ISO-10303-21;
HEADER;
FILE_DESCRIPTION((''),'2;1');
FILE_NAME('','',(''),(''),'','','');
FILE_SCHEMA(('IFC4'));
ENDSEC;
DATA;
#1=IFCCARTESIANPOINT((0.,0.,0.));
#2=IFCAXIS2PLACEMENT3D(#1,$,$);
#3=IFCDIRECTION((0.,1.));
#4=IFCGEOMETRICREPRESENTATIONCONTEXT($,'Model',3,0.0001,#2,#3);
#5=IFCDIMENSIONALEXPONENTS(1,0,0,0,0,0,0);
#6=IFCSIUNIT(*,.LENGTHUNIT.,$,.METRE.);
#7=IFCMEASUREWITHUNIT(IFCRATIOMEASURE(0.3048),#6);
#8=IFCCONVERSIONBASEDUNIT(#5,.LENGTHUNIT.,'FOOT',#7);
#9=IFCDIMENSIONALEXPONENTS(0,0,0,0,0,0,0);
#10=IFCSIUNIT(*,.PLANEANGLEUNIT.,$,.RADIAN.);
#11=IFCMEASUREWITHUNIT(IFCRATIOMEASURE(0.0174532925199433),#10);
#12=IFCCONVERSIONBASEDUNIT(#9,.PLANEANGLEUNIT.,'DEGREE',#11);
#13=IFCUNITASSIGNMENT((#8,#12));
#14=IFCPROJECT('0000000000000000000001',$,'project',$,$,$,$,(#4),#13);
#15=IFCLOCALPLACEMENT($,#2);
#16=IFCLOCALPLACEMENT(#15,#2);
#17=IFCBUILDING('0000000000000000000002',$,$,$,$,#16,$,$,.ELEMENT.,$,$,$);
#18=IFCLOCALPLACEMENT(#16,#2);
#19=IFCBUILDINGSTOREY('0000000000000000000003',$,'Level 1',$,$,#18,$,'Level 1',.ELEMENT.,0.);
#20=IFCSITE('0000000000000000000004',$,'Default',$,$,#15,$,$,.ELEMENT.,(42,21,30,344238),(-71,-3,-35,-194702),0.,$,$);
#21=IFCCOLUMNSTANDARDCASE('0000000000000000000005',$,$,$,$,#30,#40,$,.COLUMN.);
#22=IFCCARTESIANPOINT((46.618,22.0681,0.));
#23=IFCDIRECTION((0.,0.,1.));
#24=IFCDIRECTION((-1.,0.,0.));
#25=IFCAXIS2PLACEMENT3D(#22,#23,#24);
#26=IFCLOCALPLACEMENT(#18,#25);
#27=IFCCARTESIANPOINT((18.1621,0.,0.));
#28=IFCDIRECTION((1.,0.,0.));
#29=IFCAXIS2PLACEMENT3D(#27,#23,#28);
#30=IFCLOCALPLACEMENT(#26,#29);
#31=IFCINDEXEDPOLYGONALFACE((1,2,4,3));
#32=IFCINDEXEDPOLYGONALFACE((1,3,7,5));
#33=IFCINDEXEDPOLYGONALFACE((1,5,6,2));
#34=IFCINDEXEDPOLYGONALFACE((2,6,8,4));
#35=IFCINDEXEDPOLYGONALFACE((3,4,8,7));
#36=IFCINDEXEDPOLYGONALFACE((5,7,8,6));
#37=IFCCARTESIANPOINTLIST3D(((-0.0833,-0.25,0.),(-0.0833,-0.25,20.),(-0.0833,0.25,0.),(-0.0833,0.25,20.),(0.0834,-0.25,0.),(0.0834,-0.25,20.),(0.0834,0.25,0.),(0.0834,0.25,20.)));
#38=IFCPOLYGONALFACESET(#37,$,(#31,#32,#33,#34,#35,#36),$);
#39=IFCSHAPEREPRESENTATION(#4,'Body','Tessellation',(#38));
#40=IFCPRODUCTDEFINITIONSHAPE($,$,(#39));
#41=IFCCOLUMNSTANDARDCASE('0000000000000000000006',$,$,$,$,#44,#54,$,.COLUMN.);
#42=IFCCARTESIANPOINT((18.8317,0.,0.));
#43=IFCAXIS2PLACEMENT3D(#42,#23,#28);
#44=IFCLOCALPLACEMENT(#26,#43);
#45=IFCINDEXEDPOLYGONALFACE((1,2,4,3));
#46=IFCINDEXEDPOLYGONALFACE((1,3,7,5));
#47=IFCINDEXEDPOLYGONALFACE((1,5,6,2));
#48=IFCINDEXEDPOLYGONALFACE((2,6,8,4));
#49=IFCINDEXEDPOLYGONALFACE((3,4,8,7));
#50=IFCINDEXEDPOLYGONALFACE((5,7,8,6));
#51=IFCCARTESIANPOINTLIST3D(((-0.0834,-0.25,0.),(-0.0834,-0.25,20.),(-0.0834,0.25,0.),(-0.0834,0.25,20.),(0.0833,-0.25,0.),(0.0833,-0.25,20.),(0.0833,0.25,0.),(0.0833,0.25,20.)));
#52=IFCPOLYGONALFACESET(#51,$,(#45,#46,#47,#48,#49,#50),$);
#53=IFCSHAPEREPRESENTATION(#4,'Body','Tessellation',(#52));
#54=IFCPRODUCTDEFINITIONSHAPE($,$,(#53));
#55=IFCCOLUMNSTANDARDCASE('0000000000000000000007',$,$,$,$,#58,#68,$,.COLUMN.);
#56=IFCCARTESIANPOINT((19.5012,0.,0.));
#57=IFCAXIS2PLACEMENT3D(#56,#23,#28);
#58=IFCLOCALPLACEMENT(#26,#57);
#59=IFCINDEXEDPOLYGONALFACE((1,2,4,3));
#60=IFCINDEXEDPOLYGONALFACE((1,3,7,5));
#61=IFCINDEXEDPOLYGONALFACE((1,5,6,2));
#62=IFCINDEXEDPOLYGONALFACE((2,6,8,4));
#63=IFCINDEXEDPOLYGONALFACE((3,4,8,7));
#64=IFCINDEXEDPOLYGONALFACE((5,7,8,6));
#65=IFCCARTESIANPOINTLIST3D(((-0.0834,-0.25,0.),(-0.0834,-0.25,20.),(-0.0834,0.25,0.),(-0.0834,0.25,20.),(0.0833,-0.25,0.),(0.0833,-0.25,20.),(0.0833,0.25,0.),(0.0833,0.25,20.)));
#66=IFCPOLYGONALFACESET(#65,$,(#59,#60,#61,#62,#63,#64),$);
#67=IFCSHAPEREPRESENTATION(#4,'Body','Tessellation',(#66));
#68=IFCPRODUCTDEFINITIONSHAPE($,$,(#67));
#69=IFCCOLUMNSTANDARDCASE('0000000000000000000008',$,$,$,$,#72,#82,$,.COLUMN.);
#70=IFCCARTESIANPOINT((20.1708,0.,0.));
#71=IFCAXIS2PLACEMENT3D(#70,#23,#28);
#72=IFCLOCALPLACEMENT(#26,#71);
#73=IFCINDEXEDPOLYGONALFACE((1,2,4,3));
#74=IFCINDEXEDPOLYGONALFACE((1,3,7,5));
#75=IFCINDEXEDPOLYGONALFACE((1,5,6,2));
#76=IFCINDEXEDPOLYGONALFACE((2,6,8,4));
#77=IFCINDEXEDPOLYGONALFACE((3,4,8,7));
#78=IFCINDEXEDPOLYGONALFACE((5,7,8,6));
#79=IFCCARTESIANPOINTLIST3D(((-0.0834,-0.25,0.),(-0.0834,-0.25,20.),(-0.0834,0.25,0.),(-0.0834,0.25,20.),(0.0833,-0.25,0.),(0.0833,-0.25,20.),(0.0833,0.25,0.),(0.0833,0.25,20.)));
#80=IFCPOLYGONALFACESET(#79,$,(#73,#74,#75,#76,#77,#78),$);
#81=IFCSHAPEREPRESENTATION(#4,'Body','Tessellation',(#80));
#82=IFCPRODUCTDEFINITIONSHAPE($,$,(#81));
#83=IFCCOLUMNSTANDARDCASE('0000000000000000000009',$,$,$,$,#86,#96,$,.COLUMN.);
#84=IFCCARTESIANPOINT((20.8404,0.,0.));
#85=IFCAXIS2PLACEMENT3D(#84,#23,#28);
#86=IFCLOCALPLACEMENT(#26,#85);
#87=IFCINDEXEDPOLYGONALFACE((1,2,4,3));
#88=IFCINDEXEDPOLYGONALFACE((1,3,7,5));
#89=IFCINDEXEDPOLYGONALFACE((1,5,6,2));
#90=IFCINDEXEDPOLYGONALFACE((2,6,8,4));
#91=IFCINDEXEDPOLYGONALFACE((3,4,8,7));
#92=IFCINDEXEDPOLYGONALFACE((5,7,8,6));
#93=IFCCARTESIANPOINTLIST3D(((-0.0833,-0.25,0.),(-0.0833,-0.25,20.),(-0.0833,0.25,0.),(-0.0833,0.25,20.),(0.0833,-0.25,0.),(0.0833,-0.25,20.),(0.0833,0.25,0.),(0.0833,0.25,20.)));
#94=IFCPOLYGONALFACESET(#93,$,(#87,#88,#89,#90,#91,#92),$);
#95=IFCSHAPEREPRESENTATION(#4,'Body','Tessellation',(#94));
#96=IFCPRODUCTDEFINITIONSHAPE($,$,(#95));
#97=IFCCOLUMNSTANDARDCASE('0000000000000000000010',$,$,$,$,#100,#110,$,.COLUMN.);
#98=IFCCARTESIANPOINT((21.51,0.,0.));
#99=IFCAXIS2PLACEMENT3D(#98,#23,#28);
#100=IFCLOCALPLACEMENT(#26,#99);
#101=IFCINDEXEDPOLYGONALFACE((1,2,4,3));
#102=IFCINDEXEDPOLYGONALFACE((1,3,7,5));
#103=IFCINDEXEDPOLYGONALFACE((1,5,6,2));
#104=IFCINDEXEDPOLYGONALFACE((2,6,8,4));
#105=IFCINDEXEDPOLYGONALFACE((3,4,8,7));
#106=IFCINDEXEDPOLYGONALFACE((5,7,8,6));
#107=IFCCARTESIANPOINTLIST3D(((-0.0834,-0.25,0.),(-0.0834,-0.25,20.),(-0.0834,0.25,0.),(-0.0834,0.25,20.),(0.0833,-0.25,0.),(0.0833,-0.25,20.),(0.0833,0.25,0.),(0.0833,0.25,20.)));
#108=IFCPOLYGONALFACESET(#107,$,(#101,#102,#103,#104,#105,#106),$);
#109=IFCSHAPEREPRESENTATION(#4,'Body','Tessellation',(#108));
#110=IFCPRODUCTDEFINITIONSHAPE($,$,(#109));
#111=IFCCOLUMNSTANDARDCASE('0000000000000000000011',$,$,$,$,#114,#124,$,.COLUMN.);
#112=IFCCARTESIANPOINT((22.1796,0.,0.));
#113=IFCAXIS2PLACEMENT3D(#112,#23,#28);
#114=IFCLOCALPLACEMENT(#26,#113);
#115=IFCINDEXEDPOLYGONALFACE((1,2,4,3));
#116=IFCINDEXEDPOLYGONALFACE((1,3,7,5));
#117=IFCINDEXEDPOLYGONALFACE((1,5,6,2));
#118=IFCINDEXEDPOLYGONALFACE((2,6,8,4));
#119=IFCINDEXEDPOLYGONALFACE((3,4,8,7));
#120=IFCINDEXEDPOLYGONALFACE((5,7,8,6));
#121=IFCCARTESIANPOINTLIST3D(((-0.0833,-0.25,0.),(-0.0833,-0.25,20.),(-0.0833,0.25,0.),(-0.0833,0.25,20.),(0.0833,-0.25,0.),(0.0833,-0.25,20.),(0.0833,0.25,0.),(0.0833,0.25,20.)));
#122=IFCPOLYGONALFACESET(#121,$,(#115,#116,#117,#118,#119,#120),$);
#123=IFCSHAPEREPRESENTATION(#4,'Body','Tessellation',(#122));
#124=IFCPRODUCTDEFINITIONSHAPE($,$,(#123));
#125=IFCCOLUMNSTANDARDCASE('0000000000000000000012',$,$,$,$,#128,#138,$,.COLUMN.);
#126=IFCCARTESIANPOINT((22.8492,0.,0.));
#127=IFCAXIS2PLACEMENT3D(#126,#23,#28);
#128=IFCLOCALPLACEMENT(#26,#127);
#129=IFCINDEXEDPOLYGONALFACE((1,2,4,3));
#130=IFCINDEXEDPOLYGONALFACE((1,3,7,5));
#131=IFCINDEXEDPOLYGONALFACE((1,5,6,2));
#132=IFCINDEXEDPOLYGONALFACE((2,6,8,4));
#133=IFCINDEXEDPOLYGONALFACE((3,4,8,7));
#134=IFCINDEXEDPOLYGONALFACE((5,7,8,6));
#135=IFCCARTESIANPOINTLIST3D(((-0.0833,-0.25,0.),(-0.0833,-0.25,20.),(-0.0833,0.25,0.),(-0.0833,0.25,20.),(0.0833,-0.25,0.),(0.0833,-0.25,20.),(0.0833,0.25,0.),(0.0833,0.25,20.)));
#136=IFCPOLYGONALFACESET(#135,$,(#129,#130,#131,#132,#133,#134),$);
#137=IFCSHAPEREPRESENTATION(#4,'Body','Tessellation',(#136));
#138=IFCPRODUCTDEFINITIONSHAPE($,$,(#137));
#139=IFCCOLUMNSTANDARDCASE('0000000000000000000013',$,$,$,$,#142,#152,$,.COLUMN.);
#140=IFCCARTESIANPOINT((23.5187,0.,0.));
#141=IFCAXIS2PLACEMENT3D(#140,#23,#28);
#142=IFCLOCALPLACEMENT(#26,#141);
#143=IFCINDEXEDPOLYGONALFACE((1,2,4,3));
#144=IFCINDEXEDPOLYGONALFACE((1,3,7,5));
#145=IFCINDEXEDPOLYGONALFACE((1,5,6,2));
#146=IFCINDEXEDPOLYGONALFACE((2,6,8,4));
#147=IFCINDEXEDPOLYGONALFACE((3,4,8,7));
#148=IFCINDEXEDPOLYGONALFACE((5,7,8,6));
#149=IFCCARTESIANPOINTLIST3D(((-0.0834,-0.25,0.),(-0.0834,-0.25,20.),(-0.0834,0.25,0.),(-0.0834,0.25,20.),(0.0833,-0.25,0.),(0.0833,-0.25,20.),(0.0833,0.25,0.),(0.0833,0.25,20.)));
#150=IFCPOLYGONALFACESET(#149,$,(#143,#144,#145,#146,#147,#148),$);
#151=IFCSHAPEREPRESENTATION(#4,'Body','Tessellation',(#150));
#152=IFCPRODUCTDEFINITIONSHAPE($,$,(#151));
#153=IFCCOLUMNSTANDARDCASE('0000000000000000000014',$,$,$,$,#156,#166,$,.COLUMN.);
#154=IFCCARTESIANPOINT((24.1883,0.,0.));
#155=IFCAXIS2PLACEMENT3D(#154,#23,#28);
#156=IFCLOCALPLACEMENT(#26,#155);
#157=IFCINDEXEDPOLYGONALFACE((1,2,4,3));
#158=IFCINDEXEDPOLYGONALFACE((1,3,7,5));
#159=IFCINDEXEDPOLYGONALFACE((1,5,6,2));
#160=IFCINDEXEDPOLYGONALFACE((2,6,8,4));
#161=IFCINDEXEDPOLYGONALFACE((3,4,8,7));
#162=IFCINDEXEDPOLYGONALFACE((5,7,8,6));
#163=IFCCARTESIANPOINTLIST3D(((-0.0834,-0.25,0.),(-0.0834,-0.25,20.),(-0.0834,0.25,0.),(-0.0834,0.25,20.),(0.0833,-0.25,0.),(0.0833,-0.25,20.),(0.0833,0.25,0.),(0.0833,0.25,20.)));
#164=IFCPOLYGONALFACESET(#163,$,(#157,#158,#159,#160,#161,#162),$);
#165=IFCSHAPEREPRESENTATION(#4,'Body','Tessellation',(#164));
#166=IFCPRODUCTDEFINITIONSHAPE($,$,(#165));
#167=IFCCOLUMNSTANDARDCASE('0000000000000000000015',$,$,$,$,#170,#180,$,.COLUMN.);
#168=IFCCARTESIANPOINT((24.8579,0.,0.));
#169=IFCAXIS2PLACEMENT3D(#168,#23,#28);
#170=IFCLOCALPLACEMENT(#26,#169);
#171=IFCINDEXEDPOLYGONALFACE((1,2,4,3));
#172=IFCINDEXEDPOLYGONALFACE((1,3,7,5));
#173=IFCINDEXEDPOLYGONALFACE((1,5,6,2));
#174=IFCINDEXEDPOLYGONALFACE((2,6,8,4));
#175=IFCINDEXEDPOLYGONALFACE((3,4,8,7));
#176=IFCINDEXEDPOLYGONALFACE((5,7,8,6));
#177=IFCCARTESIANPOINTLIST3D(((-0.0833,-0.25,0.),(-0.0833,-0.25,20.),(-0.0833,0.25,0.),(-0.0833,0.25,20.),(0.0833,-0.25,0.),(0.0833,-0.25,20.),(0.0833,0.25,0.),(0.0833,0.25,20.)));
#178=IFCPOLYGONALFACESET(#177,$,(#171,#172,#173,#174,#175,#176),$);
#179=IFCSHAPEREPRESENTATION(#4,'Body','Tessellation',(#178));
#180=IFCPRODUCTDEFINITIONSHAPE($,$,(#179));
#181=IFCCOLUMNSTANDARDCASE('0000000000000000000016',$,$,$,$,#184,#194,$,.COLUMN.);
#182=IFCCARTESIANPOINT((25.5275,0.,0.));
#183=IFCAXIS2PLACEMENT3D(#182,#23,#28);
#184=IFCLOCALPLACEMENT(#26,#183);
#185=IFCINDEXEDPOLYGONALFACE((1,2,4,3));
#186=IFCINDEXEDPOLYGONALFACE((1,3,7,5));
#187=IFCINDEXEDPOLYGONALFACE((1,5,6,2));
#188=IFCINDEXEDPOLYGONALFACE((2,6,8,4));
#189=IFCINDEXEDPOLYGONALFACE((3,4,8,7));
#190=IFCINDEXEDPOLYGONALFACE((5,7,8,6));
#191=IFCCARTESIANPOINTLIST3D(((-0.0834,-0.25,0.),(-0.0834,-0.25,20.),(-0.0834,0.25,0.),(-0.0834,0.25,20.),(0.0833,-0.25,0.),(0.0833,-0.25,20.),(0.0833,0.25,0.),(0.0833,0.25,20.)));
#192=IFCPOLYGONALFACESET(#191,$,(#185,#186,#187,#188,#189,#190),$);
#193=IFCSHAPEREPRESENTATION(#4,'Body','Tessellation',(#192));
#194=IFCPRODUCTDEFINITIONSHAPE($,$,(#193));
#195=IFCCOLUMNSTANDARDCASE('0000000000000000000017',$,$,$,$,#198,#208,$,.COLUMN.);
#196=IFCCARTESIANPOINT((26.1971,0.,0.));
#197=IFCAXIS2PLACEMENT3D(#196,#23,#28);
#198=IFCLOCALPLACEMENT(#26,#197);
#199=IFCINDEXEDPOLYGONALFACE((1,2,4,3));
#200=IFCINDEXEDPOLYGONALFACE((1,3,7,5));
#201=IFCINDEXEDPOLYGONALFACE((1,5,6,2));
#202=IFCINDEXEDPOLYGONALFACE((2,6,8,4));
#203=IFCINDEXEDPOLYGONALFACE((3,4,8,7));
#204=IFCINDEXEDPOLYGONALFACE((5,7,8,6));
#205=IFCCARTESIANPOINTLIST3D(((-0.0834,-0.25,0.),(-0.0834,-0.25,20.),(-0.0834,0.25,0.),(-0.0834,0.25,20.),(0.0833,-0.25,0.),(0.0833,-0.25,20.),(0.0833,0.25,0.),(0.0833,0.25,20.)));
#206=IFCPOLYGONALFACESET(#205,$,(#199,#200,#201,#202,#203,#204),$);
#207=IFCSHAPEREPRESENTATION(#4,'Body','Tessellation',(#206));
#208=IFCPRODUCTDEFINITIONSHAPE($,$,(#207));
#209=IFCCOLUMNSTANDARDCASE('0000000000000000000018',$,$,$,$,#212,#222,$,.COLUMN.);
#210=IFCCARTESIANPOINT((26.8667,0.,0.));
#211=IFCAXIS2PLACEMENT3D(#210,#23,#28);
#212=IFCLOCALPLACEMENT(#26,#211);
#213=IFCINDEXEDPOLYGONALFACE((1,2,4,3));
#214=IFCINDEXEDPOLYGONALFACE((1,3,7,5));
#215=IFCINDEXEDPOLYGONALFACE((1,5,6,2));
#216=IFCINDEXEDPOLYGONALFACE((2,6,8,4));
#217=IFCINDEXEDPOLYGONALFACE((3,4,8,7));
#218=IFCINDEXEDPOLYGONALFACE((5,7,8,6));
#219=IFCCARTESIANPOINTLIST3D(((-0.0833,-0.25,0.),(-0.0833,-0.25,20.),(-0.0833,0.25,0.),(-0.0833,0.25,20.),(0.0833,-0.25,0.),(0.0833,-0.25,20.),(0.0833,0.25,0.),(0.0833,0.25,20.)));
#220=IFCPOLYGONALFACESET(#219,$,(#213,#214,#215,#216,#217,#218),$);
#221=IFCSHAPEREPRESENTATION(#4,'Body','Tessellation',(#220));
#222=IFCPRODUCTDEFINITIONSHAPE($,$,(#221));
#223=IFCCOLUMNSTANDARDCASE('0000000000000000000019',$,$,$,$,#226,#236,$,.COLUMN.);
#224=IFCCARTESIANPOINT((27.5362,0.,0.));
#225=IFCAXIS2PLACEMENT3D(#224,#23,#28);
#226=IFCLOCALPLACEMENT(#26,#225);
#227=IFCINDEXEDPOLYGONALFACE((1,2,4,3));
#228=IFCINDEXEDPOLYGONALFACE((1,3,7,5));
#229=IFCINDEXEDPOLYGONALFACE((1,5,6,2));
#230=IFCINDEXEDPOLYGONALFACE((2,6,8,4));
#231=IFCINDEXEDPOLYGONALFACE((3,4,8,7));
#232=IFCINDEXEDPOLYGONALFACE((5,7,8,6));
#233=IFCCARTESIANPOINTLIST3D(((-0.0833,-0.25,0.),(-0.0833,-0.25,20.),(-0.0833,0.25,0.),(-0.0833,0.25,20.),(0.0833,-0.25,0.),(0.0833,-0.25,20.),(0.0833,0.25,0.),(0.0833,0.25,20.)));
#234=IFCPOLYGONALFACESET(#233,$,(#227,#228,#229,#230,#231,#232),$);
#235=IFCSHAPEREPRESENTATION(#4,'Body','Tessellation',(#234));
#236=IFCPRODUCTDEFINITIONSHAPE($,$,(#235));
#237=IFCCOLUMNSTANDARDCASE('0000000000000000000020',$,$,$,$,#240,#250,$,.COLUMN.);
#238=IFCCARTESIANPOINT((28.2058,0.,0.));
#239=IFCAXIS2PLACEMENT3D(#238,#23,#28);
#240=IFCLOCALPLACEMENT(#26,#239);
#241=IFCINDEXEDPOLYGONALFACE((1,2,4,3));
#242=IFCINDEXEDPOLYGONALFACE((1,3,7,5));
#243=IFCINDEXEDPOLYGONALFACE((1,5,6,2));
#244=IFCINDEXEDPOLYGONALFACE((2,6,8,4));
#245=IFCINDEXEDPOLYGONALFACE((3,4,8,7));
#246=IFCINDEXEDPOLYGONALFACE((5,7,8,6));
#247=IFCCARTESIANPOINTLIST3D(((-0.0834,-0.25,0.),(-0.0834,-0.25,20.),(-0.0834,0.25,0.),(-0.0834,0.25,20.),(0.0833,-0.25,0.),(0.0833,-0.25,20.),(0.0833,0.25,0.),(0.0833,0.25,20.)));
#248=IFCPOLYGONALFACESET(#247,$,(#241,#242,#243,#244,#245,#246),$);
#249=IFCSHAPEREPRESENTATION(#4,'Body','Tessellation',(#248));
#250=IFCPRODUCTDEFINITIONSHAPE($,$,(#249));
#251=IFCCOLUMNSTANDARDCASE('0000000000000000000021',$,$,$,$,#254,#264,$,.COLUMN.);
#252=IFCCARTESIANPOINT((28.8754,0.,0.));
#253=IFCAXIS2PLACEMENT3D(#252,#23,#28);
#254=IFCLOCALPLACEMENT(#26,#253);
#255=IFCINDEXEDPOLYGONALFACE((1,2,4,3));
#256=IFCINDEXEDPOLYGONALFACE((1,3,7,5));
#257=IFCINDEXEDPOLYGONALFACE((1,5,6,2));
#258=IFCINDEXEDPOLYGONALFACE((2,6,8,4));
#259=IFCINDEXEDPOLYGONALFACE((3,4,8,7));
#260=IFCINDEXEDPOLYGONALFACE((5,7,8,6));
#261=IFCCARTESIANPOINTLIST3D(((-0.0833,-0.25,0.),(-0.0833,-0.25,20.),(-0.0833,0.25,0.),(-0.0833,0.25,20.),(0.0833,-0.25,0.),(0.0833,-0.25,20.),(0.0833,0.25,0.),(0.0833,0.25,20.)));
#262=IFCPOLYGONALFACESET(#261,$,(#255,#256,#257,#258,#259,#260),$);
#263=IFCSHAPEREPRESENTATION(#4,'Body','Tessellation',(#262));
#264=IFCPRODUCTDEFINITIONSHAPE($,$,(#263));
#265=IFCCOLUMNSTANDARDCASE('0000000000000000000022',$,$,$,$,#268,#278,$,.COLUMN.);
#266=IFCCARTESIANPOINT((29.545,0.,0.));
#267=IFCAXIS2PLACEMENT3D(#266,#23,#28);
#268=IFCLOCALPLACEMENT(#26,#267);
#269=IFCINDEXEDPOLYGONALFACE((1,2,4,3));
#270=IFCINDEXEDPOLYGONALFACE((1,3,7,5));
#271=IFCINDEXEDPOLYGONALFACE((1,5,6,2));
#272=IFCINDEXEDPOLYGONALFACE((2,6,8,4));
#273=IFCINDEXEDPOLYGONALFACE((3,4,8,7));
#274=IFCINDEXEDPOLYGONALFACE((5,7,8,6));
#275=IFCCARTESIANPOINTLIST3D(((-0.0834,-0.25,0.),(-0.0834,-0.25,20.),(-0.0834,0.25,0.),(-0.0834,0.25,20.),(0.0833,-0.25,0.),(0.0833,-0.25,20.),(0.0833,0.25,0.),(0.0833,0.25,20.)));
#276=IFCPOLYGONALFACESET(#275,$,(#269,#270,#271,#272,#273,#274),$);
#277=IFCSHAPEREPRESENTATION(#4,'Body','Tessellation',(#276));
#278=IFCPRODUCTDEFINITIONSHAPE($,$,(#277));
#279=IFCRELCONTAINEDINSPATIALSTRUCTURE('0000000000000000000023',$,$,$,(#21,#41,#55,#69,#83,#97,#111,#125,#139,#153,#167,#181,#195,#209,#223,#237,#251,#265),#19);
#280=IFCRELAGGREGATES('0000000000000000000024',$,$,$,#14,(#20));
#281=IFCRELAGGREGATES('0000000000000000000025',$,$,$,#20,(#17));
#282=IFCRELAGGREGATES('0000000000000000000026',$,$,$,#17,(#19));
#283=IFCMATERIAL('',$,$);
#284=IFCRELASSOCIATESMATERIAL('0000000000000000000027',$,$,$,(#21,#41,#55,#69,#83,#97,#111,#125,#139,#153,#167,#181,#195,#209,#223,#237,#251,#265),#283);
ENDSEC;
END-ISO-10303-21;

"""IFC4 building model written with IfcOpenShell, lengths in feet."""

from ifc_helpers import new_model, entity, si_unit, converted_unit, direction, frame, origin, place, context, project, spatial, rectangle, extrude, material, element, save


model = new_model("IFC4")

# Units and contexts
model_context = context("Model", 3, precision=0.0001, world=origin(), true_north=direction((0.0, 1.0)))
ifc_project = project(units=[converted_unit("LENGTHUNIT", "FOOT", entity("IfcRatioMeasure", 0.3048), si_unit("LENGTHUNIT", "METRE"), dimensions=[1, 0, 0, 0, 0, 0, 0]), converted_unit("PLANEANGLEUNIT", "DEGREE", entity("IfcRatioMeasure", 0.0174532925199433), si_unit("PLANEANGLEUNIT", "RADIAN"), dimensions=[0, 0, 0, 0, 0, 0, 0])], contexts=[model_context])

# Site, building, storey
site_placement = place(None, origin())
site = spatial("IfcSite", under=ifc_project, at=site_placement, Name="Default", CompositionType="ELEMENT", RefLatitude=(42, 21, 30, 344238), RefLongitude=(-71, -3, -35, -194702), RefElevation=0.0)
building_placement = place(site_placement, origin())
building = spatial("IfcBuilding", under=site, at=building_placement, CompositionType="ELEMENT")
storey_placement = place(building_placement, origin())
storey = spatial("IfcBuildingStorey", under=building, at=storey_placement, Name="Level 1", LongName="Level 1", CompositionType="ELEMENT", Elevation=0.0)

# Columns
ifc_material = material(Name="")
placement = place(storey_placement, frame((46.618, 22.0681, 0.0), z_axis=(0.0, 0.0, 1.0), x_axis=(-1.0, 0.0, 0.0)))
for number, where, z_axis, x_axis in (
    (1, (18.1621, 0.0, 0.0), (0.0, 0.0, 1.0), (1.0, 0.0, 0.0)),
    (2, (18.8317, 0.0, 0.0), (0.0, 0.0, 1.0), (1.0, 0.0, 0.0)),
    (3, (19.5012, 0.0, 0.0), (0.0, 0.0, 1.0), (1.0, 0.0, 0.0)),
    (4, (20.1708, 0.0, 0.0), (0.0, 0.0, 1.0), (1.0, 0.0, 0.0)),
    (5, (20.8404, 0.0, 0.0), (0.0, 0.0, 1.0), (1.0, 0.0, 0.0)),
    (6, (21.51, 0.0, 0.0), (0.0, 0.0, 1.0), (1.0, 0.0, 0.0)),
    (7, (22.1796, 0.0, 0.0), (0.0, 0.0, 1.0), (1.0, 0.0, 0.0)),
    (8, (22.8492, 0.0, 0.0), (0.0, 0.0, 1.0), (1.0, 0.0, 0.0)),
    (9, (23.5187, 0.0, 0.0), (0.0, 0.0, 1.0), (1.0, 0.0, 0.0)),
    (10, (24.1883, 0.0, 0.0), (0.0, 0.0, 1.0), (1.0, 0.0, 0.0)),
    (11, (24.8579, 0.0, 0.0), (0.0, 0.0, 1.0), (1.0, 0.0, 0.0)),
    (12, (25.5275, 0.0, 0.0), (0.0, 0.0, 1.0), (1.0, 0.0, 0.0)),
    (13, (26.1971, 0.0, 0.0), (0.0, 0.0, 1.0), (1.0, 0.0, 0.0)),
    (14, (26.8667, 0.0, 0.0), (0.0, 0.0, 1.0), (1.0, 0.0, 0.0)),
    (15, (27.5362, 0.0, 0.0), (0.0, 0.0, 1.0), (1.0, 0.0, 0.0)),
    (16, (28.2058, 0.0, 0.0), (0.0, 0.0, 1.0), (1.0, 0.0, 0.0)),
    (17, (28.8754, 0.0, 0.0), (0.0, 0.0, 1.0), (1.0, 0.0, 0.0)),
    (18, (29.545, 0.0, 0.0), (0.0, 0.0, 1.0), (1.0, 0.0, 0.0)),
):
    element("IfcColumnStandardCase", number, at=place(placement, frame(where, z_axis=z_axis, x_axis=x_axis)), inside=storey, material=ifc_material, PredefinedType="COLUMN", context=model_context, shape_type="SweptSolid", body=[
        extrude(rectangle(XDim=0.1667, YDim=0.5), origin(), (0.0, 0.0, 1.0), 20.0),
    ])

save(model, "model.ifc")
